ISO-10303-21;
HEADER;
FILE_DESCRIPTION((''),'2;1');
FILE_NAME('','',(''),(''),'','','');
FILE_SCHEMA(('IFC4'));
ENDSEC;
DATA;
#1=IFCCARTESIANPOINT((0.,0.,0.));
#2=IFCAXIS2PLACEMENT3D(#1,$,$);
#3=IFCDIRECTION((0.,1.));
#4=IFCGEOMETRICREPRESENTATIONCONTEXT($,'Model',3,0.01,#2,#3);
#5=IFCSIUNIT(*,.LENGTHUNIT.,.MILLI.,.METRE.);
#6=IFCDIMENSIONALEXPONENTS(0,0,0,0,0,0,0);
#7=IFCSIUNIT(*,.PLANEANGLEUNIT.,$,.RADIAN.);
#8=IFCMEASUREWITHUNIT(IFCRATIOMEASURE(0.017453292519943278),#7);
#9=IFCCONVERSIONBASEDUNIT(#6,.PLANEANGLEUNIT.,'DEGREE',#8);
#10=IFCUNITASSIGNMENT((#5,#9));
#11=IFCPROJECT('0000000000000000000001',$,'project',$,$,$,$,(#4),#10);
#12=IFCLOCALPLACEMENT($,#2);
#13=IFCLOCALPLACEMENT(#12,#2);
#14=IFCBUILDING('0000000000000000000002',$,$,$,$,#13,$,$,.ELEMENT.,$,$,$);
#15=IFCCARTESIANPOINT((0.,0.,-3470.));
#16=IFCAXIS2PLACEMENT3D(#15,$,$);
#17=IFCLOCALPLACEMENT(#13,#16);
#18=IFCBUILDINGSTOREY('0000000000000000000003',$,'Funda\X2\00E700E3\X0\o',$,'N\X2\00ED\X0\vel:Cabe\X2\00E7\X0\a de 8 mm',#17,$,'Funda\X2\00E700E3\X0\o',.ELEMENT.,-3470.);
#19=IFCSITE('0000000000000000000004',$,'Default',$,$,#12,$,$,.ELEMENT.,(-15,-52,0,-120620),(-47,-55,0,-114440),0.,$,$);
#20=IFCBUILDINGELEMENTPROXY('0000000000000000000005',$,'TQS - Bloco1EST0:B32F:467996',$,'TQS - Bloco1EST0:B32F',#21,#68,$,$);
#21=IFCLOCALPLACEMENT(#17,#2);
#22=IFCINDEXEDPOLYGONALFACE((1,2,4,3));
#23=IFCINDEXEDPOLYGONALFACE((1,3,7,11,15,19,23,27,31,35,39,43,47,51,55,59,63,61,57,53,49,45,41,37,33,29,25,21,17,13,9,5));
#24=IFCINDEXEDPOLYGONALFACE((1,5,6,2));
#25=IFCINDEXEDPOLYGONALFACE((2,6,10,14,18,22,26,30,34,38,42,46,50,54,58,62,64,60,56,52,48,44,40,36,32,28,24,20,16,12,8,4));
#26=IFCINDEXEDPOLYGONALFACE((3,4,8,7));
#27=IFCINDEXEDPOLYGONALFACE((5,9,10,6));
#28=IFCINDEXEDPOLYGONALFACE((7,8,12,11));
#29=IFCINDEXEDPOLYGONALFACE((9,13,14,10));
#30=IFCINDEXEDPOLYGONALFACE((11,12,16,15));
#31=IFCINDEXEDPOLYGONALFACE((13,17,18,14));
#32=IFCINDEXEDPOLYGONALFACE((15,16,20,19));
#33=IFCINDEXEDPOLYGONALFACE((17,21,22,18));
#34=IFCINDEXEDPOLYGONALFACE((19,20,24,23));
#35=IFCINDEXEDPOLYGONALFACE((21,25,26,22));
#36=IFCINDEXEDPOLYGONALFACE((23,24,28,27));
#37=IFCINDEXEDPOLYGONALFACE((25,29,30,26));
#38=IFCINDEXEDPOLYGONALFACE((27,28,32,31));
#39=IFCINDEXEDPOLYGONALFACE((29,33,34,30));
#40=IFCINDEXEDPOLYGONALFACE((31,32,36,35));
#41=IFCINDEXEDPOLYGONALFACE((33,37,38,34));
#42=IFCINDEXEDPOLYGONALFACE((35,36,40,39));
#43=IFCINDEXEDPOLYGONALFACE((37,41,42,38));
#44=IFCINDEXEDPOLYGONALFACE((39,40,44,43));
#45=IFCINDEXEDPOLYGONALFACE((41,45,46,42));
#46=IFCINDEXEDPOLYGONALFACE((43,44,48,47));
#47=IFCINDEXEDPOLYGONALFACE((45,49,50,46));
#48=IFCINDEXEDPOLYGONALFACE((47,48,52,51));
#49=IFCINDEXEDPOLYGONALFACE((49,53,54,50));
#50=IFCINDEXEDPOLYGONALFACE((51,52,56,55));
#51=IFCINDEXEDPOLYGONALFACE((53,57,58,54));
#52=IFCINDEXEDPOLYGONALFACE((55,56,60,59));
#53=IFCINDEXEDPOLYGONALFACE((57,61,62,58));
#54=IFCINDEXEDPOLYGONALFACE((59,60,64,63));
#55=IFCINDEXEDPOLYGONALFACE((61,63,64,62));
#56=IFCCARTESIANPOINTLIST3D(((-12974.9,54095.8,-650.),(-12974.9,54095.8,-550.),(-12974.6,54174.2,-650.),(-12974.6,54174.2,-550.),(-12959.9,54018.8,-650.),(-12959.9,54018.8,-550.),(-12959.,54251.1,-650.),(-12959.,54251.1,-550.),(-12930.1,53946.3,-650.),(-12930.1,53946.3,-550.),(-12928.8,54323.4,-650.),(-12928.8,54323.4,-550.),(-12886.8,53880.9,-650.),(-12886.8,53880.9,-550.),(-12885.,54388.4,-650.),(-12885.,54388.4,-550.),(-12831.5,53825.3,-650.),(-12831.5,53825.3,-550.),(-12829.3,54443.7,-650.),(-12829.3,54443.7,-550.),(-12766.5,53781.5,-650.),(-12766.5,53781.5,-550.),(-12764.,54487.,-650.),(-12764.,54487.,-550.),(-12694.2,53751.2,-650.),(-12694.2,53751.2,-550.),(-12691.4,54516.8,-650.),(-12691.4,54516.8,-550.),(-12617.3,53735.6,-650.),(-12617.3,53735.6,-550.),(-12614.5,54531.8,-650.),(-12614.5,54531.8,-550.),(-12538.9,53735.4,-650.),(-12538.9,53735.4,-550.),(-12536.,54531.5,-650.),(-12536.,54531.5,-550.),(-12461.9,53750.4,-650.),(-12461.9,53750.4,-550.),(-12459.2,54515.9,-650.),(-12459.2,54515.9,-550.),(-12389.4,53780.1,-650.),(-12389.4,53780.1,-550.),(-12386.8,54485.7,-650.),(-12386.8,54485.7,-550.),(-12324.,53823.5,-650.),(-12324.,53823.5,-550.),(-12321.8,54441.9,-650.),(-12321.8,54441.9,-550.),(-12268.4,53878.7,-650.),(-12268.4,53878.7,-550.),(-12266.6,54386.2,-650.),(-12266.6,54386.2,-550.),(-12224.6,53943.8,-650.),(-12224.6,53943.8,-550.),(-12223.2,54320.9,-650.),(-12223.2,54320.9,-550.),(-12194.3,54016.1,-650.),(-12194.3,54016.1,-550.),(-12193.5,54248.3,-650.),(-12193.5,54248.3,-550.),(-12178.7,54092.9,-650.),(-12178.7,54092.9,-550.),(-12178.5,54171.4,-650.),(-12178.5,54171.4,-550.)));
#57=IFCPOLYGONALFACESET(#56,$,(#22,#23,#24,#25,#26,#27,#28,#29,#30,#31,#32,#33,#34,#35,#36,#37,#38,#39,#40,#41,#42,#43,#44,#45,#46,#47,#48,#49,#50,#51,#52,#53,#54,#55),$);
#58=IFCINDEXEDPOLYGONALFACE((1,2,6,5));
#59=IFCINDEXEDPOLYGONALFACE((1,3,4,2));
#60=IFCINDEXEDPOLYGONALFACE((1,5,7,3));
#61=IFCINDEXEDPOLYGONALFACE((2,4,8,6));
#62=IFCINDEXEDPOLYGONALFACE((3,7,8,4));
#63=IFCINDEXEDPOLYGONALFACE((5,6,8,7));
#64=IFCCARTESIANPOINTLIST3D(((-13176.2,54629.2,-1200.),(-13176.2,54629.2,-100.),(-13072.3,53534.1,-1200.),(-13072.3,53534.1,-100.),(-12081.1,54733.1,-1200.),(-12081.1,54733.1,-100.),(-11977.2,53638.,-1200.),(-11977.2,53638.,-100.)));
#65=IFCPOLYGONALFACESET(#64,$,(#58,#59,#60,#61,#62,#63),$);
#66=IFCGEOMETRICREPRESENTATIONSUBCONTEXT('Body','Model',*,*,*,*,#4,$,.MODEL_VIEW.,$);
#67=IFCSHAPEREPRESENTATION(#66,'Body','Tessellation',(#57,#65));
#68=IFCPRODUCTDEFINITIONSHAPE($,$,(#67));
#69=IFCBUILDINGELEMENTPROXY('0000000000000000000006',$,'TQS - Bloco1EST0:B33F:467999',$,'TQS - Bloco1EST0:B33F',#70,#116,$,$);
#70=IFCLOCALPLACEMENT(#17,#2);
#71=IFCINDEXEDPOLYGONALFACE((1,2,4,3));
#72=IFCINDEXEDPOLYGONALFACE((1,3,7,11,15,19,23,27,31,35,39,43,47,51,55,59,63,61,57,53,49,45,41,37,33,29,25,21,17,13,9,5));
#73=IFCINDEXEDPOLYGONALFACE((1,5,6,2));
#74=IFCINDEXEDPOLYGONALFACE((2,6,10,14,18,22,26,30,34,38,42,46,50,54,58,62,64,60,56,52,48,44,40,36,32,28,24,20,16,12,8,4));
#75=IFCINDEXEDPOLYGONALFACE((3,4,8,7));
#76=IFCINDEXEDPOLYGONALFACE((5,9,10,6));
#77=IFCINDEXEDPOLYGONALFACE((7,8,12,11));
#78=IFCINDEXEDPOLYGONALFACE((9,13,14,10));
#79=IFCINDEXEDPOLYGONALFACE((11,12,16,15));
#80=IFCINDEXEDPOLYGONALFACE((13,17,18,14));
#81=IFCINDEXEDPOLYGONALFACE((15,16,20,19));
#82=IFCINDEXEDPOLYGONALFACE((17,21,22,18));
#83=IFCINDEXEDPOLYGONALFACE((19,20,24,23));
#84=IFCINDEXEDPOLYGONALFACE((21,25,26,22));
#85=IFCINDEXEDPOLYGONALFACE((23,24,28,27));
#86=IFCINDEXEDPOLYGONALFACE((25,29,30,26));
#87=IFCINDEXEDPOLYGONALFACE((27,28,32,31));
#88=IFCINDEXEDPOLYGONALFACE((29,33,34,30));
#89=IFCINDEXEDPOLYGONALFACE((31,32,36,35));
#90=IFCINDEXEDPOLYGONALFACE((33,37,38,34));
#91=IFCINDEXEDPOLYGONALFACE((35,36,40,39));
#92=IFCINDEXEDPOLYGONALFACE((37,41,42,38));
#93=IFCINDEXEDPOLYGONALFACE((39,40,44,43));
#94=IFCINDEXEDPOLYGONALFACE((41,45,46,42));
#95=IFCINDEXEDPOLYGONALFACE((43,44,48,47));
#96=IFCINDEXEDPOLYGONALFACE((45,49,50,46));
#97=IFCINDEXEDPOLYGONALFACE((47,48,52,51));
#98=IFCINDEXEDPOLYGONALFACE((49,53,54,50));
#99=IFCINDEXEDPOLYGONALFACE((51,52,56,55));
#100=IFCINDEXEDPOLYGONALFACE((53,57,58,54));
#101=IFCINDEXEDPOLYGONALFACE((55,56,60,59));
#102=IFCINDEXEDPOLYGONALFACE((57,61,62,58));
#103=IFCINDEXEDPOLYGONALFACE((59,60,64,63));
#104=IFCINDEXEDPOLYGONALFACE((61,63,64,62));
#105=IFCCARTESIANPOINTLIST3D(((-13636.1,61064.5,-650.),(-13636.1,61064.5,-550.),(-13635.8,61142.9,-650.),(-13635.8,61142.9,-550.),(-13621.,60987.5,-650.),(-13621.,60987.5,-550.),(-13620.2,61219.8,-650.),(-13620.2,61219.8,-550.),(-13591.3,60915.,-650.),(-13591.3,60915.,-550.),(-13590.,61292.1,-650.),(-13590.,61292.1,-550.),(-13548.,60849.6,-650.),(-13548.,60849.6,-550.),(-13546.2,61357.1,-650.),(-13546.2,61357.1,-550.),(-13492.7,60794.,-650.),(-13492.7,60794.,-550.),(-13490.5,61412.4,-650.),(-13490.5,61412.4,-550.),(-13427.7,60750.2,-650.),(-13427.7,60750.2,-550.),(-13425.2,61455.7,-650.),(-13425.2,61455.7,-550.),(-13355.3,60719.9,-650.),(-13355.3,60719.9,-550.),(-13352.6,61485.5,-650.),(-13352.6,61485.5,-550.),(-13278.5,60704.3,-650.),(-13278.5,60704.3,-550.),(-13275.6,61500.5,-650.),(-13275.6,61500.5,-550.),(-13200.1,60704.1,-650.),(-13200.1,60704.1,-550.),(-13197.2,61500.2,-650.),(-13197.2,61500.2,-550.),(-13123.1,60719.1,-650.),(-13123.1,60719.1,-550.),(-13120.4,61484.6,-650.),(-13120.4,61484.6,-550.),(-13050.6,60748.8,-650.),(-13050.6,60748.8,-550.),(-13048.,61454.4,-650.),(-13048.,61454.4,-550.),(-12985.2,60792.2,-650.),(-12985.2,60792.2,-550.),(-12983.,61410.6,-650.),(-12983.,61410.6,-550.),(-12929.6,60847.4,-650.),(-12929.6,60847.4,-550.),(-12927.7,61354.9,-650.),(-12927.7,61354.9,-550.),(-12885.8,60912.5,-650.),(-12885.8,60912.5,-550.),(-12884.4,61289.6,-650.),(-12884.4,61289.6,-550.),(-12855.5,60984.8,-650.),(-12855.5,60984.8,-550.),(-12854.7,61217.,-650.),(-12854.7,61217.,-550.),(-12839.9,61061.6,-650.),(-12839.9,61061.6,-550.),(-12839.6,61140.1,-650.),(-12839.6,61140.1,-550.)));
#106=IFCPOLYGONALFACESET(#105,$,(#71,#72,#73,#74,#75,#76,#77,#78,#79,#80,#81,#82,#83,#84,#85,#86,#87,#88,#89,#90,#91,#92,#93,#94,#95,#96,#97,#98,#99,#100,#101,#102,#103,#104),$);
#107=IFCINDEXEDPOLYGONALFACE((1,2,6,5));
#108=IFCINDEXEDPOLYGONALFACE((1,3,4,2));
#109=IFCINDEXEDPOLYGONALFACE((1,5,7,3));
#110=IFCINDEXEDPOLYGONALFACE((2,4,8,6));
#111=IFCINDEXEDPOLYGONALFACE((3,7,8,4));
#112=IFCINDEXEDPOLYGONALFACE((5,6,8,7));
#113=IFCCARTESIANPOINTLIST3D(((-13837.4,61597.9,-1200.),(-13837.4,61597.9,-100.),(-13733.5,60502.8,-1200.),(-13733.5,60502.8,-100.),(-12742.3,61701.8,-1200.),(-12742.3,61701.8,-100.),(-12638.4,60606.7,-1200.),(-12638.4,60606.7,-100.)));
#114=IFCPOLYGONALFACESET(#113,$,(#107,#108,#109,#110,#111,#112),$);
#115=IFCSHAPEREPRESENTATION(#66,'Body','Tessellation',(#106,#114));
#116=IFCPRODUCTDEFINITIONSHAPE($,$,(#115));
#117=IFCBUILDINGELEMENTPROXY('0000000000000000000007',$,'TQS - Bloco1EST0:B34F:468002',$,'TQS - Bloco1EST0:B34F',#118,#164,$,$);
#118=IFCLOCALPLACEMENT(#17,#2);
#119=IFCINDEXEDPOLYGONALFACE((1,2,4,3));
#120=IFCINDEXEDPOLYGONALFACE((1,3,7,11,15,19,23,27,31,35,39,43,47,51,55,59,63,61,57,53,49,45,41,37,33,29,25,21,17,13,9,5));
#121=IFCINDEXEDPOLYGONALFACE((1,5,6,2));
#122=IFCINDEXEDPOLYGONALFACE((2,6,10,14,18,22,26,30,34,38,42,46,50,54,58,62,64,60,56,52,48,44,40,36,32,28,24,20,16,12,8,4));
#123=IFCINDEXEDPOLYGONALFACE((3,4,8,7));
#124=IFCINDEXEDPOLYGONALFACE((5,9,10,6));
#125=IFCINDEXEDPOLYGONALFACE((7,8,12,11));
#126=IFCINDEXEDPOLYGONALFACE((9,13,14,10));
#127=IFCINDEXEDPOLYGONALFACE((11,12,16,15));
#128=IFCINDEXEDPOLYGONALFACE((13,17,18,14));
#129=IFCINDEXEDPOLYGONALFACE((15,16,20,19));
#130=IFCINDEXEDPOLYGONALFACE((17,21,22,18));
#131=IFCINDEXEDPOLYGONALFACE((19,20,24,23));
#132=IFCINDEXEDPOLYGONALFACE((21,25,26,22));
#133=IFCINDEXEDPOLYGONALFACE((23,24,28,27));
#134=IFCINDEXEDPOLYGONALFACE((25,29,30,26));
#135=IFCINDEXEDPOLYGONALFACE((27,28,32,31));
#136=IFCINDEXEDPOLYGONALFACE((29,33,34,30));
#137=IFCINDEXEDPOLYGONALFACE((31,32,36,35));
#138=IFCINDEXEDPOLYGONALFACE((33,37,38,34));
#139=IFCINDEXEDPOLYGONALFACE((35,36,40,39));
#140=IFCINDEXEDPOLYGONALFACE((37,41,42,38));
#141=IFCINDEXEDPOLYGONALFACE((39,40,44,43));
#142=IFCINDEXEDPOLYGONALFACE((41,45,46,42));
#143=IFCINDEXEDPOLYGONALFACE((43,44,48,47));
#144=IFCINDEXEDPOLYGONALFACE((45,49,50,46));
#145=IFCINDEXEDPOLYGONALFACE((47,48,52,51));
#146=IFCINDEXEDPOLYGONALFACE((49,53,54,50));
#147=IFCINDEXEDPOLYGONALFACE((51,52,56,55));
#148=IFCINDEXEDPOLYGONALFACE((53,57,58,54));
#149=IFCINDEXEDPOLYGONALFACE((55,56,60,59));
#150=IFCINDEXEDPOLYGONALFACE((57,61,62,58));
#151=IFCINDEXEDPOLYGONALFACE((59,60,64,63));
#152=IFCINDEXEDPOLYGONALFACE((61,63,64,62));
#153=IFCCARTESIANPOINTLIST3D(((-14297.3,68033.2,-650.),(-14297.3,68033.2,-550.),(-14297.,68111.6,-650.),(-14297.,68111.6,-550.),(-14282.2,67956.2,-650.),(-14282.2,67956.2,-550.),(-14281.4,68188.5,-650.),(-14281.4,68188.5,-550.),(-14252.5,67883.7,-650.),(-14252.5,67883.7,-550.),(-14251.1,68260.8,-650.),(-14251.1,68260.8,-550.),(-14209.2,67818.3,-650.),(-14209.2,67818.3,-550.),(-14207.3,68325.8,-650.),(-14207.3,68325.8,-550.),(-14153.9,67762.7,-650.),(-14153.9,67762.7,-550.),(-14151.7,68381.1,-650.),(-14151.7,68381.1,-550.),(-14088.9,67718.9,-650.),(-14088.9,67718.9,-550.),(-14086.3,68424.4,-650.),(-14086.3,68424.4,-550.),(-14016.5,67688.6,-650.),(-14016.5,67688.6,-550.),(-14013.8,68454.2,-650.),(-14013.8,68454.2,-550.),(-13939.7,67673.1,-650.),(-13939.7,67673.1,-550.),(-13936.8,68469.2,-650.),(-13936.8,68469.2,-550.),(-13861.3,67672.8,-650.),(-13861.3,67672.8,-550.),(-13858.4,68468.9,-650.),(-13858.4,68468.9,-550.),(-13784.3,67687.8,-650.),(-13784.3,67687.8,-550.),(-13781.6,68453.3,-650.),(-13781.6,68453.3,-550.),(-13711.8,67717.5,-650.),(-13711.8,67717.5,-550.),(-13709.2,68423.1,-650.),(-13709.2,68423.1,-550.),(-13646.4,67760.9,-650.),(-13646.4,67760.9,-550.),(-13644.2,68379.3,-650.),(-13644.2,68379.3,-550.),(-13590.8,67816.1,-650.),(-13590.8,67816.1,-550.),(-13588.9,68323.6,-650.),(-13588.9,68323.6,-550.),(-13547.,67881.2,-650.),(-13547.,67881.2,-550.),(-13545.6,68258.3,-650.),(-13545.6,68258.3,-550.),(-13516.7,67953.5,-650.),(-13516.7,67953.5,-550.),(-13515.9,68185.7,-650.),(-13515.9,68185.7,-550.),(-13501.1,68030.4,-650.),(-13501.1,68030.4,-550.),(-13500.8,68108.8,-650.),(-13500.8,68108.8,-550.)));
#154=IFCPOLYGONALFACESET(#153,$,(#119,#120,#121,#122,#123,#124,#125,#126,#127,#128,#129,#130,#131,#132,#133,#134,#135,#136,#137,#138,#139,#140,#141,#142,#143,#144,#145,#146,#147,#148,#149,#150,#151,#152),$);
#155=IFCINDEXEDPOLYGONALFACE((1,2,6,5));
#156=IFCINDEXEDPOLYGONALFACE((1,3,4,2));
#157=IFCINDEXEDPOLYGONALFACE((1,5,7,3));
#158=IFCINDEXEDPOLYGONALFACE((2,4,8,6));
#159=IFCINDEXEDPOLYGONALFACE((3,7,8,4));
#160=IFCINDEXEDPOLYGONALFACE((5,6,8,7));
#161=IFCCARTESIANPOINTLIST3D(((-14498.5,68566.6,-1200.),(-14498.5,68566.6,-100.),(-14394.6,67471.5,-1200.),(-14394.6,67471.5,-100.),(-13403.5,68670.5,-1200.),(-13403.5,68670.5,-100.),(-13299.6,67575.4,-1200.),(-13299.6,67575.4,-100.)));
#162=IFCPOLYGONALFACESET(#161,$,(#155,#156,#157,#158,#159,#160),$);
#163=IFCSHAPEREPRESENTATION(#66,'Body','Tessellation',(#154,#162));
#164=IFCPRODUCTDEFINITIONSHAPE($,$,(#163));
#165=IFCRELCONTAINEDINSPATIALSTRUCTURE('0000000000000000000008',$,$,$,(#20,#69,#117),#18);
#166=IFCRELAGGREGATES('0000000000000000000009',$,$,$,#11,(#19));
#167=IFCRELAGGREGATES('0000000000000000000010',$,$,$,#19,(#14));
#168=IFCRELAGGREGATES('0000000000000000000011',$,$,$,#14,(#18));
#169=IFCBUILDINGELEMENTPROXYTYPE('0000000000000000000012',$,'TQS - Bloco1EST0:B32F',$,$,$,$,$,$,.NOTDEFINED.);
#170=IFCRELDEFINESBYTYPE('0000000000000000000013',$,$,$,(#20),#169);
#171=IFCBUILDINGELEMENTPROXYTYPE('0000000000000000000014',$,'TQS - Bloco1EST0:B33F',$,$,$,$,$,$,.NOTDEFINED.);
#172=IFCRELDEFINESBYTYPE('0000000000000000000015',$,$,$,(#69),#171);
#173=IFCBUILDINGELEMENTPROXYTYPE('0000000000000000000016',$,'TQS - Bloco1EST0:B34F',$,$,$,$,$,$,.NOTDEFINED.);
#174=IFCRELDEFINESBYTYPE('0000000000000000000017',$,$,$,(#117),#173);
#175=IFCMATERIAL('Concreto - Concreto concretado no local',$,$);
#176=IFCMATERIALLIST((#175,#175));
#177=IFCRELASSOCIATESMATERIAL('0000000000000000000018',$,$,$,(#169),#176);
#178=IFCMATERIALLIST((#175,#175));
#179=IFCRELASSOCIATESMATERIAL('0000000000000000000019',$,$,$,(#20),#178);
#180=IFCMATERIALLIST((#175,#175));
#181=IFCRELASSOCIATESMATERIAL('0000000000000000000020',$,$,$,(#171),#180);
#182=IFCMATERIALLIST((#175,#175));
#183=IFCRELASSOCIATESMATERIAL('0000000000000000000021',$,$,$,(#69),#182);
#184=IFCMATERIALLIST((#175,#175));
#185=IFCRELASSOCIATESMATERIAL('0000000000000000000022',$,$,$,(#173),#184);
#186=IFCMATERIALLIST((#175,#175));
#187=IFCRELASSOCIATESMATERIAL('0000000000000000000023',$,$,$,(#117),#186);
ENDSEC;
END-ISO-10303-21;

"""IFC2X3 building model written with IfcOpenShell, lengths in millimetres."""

from ifc_helpers import new_model, entity, si_unit, converted_unit, direction, frame, frame_2d, origin, origin_2d_with_axis, place, context, subcontext, project, spatial, rectangle, circle, extrude, source, transform, mapped, material, material_list, type_object, type_shapes, element, save


model = new_model("IFC2X3")

# Units and contexts
model_context = context("Model", 3, precision=0.01, world=origin(), true_north=direction((0.0, 1.0)))
body_context = subcontext(model_context, "Body", "Model", "MODEL_VIEW")
ifc_project = project(units=[si_unit("LENGTHUNIT", "METRE", prefix="MILLI"), converted_unit("PLANEANGLEUNIT", "DEGREE", entity("IfcRatioMeasure", 0.017453292519943278), si_unit("PLANEANGLEUNIT", "RADIAN"), dimensions=[0, 0, 0, 0, 0, 0, 0])], contexts=[model_context])

# Site, building, storey
site_placement = place(None, origin())
site = spatial("IfcSite", under=ifc_project, at=site_placement, Name="Default", CompositionType="ELEMENT", RefLatitude=(-15, -52, 0, -120620), RefLongitude=(-47, -55, 0, -114440), RefElevation=0.0)
building_placement = place(site_placement, origin())
building = spatial("IfcBuilding", under=site, at=building_placement, CompositionType="ELEMENT")
storey_placement = place(building_placement, frame((0.0, 0.0, -3470.0)))
storey = spatial("IfcBuildingStorey", under=building, at=storey_placement, Name="Fundação", ObjectType="Nível:Cabeça de 8 mm", LongName="Fundação", CompositionType="ELEMENT", Elevation=-3470.0)

# Building element proxies
ifc_material_1 = material(Name="Concreto - Concreto concretado no local")
ifc_material_list_1 = material_list([ifc_material_1, ifc_material_1])
ifc_material_list_2 = material_list([ifc_material_1, ifc_material_1])
building_element_proxy_type_1 = type_object("IfcBuildingElementProxyType", Name="TQS - Bloco1EST0:B32F", PredefinedType="NOTDEFINED", material=ifc_material_list_2)
shared_shape_1 = source(origin(), body_context, "Body", "SweptSolid", [
    extrude(circle(Radius=400.0, at=frame_2d((0.0, 0.0), x_axis=(1.0, 0.0))), frame((0.0, 0.0, -550.0)), (0.0, 0.0, 1.0), 100.0),
    extrude(rectangle(XDim=1100.0, YDim=1100.0, at=origin_2d_with_axis()), frame((0.0, 0.0, -1100.0), z_axis=(0.0, 0.0, 1.0), x_axis=(-1.0, 0.0, 0.0)), (0.0, 0.0, 1.0), 1100.0),
])
type_shapes(building_element_proxy_type_1, [shared_shape_1])
proxy_1_placement = place(storey_placement, frame((-12576.7, 54133.6, -100.0), z_axis=(0.0, 0.0, 1.0), x_axis=(-0.094456, 0.995529, 0.0)))
element("IfcBuildingElementProxy", 1, at=proxy_1_placement, inside=storey, type_object=building_element_proxy_type_1, material=ifc_material_list_1, Name="TQS - Bloco1EST0:B32F:467996", ObjectType="TQS - Bloco1EST0:B32F", context=body_context, shape_type="MappedRepresentation", body=[
    mapped(shared_shape_1, transform((0.0, 0.0, 0.0), scale=1.0)),
])
ifc_material_list_3 = material_list([ifc_material_1, ifc_material_1])
ifc_material_list_4 = material_list([ifc_material_1, ifc_material_1])
building_element_proxy_type_2 = type_object("IfcBuildingElementProxyType", Name="TQS - Bloco1EST0:B33F", PredefinedType="NOTDEFINED", material=ifc_material_list_4)
shared_shape_2 = source(origin(), body_context, "Body", "SweptSolid", [
    extrude(circle(Radius=400.0, at=frame_2d((0.0, 0.0), x_axis=(1.0, 0.0))), frame((0.0, 0.0, -550.0)), (0.0, 0.0, 1.0), 100.0),
    extrude(rectangle(XDim=1100.0, YDim=1100.0, at=origin_2d_with_axis()), frame((0.0, 0.0, -1100.0), z_axis=(0.0, 0.0, 1.0), x_axis=(-1.0, 0.0, 0.0)), (0.0, 0.0, 1.0), 1100.0),
])
type_shapes(building_element_proxy_type_2, [shared_shape_2])
proxy_2_placement = place(storey_placement, frame((-13237.9, 61102.3, -100.0), z_axis=(0.0, 0.0, 1.0), x_axis=(-0.094456, 0.995529, 0.0)))
element("IfcBuildingElementProxy", 2, at=proxy_2_placement, inside=storey, type_object=building_element_proxy_type_2, material=ifc_material_list_3, Name="TQS - Bloco1EST0:B33F:467999", ObjectType="TQS - Bloco1EST0:B33F", context=body_context, shape_type="MappedRepresentation", body=[
    mapped(shared_shape_2, transform((0.0, 0.0, 0.0), scale=1.0)),
])
ifc_material_list_5 = material_list([ifc_material_1, ifc_material_1])
ifc_material_list_6 = material_list([ifc_material_1, ifc_material_1])
building_element_proxy_type_3 = type_object("IfcBuildingElementProxyType", Name="TQS - Bloco1EST0:B34F", PredefinedType="NOTDEFINED", material=ifc_material_list_6)
shared_shape_3 = source(origin(), body_context, "Body", "SweptSolid", [
    extrude(circle(Radius=400.0, at=frame_2d((0.0, 0.0), x_axis=(1.0, 0.0))), frame((0.0, 0.0, -550.0)), (0.0, 0.0, 1.0), 100.0),
    extrude(rectangle(XDim=1100.0, YDim=1100.0, at=origin_2d_with_axis()), frame((0.0, 0.0, -1100.0), z_axis=(0.0, 0.0, 1.0), x_axis=(-1.0, 0.0, 0.0)), (0.0, 0.0, 1.0), 1100.0),
])
type_shapes(building_element_proxy_type_3, [shared_shape_3])
proxy_3_placement = place(storey_placement, frame((-13899.1, 68071.0, -100.0), z_axis=(0.0, 0.0, 1.0), x_axis=(-0.094456, 0.995529, 0.0)))
element("IfcBuildingElementProxy", 3, at=proxy_3_placement, inside=storey, type_object=building_element_proxy_type_3, material=ifc_material_list_5, Name="TQS - Bloco1EST0:B34F:468002", ObjectType="TQS - Bloco1EST0:B34F", context=body_context, shape_type="MappedRepresentation", body=[
    mapped(shared_shape_3, transform((0.0, 0.0, 0.0), scale=1.0)),
])

save(model, "model.ifc")
